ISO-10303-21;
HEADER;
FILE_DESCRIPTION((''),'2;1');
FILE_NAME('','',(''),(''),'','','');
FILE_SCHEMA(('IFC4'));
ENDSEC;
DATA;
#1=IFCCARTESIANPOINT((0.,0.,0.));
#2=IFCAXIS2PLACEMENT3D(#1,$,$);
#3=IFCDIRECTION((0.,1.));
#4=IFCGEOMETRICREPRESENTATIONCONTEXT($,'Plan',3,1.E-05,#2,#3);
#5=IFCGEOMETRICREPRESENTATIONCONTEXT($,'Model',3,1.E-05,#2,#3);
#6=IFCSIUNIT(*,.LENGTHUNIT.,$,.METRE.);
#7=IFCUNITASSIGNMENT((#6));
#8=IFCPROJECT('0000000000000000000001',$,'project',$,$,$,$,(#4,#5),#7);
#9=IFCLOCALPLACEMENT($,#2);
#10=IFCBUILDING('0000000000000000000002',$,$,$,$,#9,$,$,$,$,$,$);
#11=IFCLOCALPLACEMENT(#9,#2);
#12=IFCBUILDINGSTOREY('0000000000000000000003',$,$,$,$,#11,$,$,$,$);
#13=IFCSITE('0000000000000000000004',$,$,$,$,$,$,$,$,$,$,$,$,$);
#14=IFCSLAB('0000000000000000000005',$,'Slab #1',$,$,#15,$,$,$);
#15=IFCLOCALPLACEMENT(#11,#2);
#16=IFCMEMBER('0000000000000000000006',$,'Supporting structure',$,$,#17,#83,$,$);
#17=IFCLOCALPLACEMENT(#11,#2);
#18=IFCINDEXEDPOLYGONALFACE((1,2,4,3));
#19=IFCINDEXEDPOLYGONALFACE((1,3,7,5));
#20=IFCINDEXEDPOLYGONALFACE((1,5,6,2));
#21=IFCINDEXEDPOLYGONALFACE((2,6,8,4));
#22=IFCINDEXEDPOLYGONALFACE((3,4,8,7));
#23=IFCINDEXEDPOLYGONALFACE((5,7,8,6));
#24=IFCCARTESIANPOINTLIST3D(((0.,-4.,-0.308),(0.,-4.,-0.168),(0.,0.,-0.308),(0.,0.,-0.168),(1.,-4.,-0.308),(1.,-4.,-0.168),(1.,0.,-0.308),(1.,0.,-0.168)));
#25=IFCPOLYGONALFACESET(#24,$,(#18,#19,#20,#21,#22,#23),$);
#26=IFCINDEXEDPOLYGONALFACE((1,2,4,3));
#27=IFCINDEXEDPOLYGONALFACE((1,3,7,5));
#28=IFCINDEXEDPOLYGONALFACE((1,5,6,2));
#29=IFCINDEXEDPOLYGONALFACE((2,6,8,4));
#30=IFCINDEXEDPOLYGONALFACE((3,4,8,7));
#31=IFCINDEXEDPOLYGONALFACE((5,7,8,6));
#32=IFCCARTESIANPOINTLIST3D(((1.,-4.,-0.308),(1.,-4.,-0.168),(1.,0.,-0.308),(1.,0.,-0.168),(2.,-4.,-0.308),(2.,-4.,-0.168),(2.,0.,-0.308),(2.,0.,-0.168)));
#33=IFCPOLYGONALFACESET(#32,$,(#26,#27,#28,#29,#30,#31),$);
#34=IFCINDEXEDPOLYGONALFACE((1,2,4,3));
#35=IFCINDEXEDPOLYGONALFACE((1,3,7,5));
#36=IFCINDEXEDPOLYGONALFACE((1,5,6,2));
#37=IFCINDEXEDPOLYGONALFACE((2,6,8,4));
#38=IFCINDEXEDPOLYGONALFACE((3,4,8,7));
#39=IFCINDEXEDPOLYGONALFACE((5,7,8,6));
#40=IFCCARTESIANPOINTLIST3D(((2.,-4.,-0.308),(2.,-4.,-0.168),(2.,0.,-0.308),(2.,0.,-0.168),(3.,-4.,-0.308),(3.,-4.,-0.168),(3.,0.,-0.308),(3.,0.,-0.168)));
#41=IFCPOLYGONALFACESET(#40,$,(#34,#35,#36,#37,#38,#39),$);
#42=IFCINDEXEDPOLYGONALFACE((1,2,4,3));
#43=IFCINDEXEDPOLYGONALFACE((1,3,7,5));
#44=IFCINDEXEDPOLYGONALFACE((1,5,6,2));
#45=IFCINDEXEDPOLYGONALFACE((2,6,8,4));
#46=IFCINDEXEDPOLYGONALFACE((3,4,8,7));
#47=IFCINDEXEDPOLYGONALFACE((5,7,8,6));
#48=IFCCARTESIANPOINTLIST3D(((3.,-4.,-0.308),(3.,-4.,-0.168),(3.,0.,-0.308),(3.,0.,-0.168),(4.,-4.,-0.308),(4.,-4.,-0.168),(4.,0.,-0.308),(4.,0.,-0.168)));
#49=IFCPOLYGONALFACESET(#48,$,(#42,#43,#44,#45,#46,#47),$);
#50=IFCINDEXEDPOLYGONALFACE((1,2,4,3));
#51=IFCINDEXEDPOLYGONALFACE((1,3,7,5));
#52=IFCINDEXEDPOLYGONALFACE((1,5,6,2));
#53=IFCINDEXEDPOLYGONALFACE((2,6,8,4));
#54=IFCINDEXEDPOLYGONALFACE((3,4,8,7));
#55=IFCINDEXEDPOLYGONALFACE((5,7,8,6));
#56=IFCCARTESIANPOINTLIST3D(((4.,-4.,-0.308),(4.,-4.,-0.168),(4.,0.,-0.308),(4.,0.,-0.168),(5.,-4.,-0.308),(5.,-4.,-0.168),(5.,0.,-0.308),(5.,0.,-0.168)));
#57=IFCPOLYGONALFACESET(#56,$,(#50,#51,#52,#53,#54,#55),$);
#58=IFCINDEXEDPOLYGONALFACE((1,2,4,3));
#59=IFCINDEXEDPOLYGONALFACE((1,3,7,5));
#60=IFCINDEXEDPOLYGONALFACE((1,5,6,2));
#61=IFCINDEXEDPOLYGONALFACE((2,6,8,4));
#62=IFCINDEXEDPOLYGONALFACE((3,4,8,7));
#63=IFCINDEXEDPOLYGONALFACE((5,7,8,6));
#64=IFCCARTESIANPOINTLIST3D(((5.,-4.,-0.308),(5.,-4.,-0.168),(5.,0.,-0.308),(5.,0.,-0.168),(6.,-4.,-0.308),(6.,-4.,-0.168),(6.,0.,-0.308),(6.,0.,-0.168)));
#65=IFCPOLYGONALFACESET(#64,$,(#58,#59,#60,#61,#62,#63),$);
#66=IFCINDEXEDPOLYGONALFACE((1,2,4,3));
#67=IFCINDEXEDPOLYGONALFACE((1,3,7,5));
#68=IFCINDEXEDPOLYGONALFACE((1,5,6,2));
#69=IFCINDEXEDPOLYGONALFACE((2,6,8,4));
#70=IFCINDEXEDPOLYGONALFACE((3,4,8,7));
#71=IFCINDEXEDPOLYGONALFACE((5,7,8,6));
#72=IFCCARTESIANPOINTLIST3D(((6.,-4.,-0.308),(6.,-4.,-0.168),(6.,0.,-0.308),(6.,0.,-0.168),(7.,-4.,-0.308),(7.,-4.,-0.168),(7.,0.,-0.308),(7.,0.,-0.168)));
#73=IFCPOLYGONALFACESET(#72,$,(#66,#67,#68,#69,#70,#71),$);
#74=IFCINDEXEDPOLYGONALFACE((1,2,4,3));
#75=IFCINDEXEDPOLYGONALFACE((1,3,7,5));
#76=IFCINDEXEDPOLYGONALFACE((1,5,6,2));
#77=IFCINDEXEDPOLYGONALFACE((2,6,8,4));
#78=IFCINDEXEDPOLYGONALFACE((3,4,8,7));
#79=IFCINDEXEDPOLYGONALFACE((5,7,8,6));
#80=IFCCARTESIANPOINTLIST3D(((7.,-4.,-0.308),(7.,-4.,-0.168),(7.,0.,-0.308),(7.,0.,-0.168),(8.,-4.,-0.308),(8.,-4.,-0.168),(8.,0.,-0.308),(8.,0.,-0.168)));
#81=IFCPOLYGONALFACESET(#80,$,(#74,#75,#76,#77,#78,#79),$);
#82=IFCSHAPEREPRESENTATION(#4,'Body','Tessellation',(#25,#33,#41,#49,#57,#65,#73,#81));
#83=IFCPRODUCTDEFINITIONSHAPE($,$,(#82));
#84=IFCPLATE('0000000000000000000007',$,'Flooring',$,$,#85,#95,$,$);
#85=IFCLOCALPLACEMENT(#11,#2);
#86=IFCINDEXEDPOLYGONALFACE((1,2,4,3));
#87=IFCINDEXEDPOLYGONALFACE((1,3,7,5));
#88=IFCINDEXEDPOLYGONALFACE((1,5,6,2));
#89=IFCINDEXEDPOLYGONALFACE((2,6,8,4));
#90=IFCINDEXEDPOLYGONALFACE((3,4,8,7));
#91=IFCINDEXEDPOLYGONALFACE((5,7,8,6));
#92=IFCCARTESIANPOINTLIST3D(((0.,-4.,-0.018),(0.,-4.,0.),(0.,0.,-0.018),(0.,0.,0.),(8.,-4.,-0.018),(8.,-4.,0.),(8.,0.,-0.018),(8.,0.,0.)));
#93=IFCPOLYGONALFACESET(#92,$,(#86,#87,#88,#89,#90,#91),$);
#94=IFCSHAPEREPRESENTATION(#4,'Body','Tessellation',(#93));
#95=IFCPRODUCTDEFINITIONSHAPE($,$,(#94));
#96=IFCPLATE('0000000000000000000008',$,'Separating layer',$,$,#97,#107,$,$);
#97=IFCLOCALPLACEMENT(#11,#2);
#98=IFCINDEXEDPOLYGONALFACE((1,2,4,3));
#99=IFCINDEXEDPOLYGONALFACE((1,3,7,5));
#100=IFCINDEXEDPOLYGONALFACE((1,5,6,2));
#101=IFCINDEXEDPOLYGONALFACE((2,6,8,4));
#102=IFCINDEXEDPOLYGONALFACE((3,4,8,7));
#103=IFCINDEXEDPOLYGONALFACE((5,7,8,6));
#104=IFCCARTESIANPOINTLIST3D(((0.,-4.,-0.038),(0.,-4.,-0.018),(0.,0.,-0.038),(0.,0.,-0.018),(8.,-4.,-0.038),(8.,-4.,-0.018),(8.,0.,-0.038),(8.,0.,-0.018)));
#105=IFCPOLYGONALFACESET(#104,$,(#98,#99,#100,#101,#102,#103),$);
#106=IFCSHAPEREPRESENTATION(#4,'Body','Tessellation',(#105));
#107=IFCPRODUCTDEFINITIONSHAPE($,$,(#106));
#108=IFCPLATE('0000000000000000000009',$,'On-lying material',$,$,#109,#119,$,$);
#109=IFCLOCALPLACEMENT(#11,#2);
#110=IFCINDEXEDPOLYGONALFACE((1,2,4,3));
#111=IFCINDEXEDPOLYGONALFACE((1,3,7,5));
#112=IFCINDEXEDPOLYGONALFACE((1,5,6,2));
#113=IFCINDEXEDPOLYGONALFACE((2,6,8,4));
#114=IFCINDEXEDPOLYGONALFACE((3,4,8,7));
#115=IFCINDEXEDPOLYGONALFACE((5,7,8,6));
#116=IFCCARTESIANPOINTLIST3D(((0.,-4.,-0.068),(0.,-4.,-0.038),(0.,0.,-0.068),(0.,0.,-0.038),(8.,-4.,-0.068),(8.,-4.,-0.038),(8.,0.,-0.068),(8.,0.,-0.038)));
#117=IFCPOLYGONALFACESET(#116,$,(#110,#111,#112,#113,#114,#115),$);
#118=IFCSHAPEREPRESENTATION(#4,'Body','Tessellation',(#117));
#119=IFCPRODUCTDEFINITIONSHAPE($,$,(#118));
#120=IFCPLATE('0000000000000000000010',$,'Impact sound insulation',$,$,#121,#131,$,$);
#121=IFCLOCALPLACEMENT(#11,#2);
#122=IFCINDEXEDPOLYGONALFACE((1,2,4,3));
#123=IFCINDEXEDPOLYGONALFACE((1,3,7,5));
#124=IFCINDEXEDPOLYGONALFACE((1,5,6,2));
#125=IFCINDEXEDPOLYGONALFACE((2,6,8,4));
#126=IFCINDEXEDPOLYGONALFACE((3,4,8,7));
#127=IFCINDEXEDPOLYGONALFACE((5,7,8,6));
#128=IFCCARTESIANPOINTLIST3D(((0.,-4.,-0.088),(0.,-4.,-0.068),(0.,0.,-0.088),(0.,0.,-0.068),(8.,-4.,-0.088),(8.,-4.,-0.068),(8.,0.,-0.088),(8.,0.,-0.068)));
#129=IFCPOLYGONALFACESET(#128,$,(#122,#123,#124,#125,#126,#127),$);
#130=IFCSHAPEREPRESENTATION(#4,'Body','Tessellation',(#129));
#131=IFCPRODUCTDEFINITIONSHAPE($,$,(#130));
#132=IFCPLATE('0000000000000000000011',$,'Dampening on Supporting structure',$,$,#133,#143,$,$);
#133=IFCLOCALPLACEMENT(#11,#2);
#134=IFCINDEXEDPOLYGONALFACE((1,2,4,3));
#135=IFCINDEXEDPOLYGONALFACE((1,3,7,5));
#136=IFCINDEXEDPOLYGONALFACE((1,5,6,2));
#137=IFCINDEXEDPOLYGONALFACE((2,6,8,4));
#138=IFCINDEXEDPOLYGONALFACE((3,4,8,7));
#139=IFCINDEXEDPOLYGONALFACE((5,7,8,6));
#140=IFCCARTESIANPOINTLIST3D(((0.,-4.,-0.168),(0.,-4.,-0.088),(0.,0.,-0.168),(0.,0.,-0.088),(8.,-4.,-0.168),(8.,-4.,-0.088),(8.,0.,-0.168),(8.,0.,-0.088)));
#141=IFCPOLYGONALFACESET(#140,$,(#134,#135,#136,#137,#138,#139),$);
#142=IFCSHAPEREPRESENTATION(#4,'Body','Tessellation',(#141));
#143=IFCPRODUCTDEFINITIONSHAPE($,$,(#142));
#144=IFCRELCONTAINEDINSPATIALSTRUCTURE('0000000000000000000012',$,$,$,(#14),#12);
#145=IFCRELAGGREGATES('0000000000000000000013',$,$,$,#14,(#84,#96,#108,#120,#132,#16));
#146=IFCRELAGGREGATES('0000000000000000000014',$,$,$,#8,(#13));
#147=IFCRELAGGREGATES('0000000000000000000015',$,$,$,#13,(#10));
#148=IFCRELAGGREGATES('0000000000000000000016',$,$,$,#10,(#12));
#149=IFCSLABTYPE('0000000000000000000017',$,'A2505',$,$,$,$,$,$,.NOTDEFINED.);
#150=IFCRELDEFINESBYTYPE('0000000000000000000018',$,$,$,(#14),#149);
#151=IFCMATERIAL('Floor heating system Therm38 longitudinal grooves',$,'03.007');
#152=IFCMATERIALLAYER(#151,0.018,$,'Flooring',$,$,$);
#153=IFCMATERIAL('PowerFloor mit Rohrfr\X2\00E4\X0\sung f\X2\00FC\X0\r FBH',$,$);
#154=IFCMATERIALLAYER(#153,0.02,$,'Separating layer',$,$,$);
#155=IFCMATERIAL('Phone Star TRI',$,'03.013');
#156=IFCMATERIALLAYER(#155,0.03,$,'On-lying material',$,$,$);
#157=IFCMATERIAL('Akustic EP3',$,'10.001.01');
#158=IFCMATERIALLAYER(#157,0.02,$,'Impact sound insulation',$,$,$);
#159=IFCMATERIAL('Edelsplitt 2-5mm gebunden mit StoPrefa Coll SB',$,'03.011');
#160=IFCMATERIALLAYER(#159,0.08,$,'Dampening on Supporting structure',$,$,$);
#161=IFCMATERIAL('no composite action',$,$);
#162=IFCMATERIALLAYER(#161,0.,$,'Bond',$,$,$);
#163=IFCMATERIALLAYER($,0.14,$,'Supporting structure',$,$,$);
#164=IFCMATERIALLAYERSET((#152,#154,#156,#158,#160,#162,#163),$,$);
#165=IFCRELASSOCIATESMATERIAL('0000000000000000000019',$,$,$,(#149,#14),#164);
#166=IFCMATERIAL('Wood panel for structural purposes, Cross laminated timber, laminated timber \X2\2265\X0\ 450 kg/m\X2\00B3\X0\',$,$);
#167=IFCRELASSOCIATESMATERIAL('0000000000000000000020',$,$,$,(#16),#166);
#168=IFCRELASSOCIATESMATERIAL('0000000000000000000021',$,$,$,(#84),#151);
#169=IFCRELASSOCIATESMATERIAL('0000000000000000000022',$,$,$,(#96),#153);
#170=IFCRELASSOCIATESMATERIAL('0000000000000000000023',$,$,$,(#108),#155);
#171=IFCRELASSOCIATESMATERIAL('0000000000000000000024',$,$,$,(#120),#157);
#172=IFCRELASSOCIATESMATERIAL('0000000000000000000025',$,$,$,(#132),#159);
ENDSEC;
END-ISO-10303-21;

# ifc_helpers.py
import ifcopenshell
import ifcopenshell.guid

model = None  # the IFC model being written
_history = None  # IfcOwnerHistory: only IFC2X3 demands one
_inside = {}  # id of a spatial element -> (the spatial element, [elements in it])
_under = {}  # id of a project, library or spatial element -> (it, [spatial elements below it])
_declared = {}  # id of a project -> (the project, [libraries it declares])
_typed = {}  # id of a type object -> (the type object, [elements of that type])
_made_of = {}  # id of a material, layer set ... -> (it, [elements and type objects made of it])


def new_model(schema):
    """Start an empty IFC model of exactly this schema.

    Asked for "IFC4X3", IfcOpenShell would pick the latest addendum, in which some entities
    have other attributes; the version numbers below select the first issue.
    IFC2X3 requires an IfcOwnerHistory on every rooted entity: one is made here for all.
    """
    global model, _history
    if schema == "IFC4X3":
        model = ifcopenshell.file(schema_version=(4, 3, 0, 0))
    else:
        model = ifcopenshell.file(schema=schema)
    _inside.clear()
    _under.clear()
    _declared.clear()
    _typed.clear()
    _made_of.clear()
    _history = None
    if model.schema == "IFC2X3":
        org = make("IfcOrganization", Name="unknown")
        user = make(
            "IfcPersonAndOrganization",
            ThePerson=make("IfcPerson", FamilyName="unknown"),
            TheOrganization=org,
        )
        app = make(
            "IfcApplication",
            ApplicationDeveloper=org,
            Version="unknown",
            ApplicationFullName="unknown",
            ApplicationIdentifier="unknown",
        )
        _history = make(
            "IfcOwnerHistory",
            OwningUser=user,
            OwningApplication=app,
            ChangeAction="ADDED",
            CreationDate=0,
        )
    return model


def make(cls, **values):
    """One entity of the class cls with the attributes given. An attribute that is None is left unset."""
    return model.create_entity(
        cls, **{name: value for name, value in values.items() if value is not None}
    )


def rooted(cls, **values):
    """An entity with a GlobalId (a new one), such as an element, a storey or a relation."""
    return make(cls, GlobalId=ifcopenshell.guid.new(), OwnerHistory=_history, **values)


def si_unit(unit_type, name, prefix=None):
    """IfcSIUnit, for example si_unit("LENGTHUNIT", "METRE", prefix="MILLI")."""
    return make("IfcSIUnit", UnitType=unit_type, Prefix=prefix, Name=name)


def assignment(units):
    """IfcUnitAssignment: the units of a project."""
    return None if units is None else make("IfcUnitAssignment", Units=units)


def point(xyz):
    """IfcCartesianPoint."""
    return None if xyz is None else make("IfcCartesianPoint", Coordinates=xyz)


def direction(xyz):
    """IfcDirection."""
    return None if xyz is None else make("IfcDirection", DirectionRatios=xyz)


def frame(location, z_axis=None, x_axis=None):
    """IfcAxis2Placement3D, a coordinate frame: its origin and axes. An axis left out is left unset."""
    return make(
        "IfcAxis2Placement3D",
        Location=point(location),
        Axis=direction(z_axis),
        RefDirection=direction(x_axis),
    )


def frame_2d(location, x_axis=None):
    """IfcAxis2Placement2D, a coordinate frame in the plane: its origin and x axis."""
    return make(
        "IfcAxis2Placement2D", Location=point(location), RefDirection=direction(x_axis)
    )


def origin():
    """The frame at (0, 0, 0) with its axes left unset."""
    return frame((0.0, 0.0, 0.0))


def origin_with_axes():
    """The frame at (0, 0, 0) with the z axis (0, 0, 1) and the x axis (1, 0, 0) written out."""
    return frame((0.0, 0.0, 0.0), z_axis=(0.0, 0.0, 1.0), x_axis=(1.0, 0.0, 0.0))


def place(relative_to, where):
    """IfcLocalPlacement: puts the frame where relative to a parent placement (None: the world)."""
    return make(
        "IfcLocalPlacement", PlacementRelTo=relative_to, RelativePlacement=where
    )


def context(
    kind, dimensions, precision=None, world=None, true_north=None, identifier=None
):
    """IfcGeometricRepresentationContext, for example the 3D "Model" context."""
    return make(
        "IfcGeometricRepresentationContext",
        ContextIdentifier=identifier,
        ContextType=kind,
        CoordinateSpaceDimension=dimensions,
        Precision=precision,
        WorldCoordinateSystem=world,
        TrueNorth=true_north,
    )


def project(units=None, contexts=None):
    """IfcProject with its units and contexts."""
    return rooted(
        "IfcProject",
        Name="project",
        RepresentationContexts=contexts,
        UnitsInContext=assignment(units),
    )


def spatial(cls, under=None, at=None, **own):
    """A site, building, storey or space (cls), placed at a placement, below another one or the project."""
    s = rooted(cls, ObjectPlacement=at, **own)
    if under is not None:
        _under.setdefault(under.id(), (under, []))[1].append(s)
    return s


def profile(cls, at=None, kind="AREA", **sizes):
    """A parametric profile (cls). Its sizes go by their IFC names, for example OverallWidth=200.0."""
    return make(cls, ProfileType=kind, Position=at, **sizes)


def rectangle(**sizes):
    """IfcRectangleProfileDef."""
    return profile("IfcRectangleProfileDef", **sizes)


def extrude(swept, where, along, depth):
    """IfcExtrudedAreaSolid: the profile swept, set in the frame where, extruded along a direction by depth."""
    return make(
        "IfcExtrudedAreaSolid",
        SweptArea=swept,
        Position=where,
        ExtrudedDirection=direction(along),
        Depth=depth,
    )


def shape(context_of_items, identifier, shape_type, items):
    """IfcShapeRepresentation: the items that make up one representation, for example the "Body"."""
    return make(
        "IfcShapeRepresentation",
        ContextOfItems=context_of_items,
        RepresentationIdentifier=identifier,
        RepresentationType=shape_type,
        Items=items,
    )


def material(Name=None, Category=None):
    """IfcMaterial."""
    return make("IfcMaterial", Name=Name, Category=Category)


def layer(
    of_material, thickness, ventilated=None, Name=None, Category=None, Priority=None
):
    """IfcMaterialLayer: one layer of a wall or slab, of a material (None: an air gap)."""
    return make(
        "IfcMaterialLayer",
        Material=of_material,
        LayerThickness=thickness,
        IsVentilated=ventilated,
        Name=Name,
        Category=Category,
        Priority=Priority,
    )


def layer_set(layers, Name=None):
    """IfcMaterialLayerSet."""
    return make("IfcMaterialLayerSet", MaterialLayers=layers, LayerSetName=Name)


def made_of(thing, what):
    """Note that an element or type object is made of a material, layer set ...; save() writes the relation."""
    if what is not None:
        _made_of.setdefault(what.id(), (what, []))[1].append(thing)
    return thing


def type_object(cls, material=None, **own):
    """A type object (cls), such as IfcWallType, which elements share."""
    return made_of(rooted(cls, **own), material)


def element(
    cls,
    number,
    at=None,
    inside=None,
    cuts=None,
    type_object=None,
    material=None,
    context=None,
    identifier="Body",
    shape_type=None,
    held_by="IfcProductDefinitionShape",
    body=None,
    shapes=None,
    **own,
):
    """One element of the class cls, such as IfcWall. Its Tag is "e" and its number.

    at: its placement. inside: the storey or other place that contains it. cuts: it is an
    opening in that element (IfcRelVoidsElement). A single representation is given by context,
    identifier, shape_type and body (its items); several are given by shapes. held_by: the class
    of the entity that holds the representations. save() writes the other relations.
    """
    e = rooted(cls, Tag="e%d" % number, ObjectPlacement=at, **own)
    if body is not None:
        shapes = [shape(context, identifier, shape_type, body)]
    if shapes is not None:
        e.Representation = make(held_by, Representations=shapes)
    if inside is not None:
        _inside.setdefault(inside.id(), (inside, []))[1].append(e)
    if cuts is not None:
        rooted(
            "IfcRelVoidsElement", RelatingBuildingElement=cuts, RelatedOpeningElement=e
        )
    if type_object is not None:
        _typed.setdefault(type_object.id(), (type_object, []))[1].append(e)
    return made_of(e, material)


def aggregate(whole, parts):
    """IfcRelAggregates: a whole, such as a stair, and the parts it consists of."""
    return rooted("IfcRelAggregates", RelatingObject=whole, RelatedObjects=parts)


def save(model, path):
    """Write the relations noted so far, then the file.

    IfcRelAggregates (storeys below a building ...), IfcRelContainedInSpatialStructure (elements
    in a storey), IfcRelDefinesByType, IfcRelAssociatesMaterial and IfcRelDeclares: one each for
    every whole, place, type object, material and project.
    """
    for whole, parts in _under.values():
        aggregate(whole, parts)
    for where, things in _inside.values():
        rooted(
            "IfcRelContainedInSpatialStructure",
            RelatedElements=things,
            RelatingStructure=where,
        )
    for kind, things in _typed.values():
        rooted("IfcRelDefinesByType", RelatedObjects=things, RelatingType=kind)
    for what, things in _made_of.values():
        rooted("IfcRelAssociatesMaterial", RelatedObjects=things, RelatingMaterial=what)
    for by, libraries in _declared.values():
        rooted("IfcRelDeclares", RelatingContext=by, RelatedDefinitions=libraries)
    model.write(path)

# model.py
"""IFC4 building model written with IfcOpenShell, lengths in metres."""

from ifc_helpers import new_model, si_unit, direction, frame, frame_2d, origin, origin_with_axes, place, context, project, spatial, rectangle, extrude, material, layer, layer_set, type_object, element, aggregate, save


model = new_model("IFC4")

# Units and contexts
plan_context = context("Plan", 3, precision=1e-05, world=origin(), true_north=direction((0.0, 1.0)))
model_context = context("Model", 3, precision=1e-05, world=origin(), true_north=direction((0.0, 1.0)))
ifc_project = project(units=[si_unit("LENGTHUNIT", "METRE")], contexts=[plan_context, model_context])

# Site, building, storey
site = spatial("IfcSite", under=ifc_project)
building_placement = place(None, origin())
building = spatial("IfcBuilding", under=site, at=building_placement)
storey_placement = place(building_placement, origin())
storey = spatial("IfcBuildingStorey", under=building, at=storey_placement)

# Slab, member, plates
ifc_material_1 = material(Name="Floor heating system Therm38 longitudinal grooves", Category="03.007")
ifc_layer_1 = layer(ifc_material_1, 0.018, Name="Flooring")
ifc_material_2 = material(Name="PowerFloor mit Rohrfräsung für FBH")
ifc_layer_2 = layer(ifc_material_2, 0.02, Name="Separating layer")
ifc_material_3 = material(Name="Phone Star TRI", Category="03.013")
ifc_layer_3 = layer(ifc_material_3, 0.03, Name="On-lying material")
ifc_material_4 = material(Name="Akustic EP3", Category="10.001.01")
ifc_layer_4 = layer(ifc_material_4, 0.02, Name="Impact sound insulation")
ifc_material_5 = material(Name="Edelsplitt 2-5mm gebunden mit StoPrefa Coll SB", Category="03.011")
ifc_layer_5 = layer(ifc_material_5, 0.08, Name="Dampening on Supporting structure")
ifc_material_6 = material(Name="no composite action")
ifc_layer_6 = layer(ifc_material_6, 0.0, Name="Bond")
ifc_layer_7 = layer(None, 0.14, Name="Supporting structure")
ifc_layer_set = layer_set([ifc_layer_1, ifc_layer_2, ifc_layer_3, ifc_layer_4, ifc_layer_5, ifc_layer_6, ifc_layer_7])
slab_type = type_object("IfcSlabType", Name="A2505", PredefinedType="NOTDEFINED", material=ifc_layer_set)
slab_placement = place(None, frame((0.0, 0.0, 0.0), z_axis=(0.0, 0.0, -1.0), x_axis=(1.0, 0.0, 0.0)))
slab = element("IfcSlab", 1, at=slab_placement, inside=storey, type_object=slab_type, material=ifc_layer_set, Name="Slab #1")
ifc_material_7 = material(Name="Wood panel for structural purposes, Cross laminated timber, laminated timber ≥ 450 kg/m³")
member_placement = place(slab_placement, origin())
member = element("IfcMember", 2, at=member_placement, material=ifc_material_7, Name="Supporting structure", context=plan_context, shape_type="SweptSolid", body=[
    extrude(rectangle(XDim=1.0, YDim=0.14, at=frame_2d((0.5, 0.07), x_axis=(1.0, 0.0))), frame((0.0, 4.0, 0.168), z_axis=(0.0, -1.0, 0.0), x_axis=(1.0, 0.0, 0.0)), (0.0, 0.0, 1.0), 4.0),
    extrude(rectangle(XDim=1.0, YDim=0.14, at=frame_2d((0.5, 0.07), x_axis=(1.0, 0.0))), frame((1.0, 4.0, 0.168), z_axis=(0.0, -1.0, 0.0), x_axis=(1.0, 0.0, 0.0)), (0.0, 0.0, 1.0), 4.0),
    extrude(rectangle(XDim=1.0, YDim=0.14, at=frame_2d((0.5, 0.07), x_axis=(1.0, 0.0))), frame((2.0, 4.0, 0.168), z_axis=(0.0, -1.0, 0.0), x_axis=(1.0, 0.0, 0.0)), (0.0, 0.0, 1.0), 4.0),
    extrude(rectangle(XDim=1.0, YDim=0.14, at=frame_2d((0.5, 0.07), x_axis=(1.0, 0.0))), frame((3.0, 4.0, 0.168), z_axis=(0.0, -1.0, 0.0), x_axis=(1.0, 0.0, 0.0)), (0.0, 0.0, 1.0), 4.0),
    extrude(rectangle(XDim=1.0, YDim=0.14, at=frame_2d((0.5, 0.07), x_axis=(1.0, 0.0))), frame((4.0, 4.0, 0.168), z_axis=(0.0, -1.0, 0.0), x_axis=(1.0, 0.0, 0.0)), (0.0, 0.0, 1.0), 4.0),
    extrude(rectangle(XDim=1.0, YDim=0.14, at=frame_2d((0.5, 0.07), x_axis=(1.0, 0.0))), frame((5.0, 4.0, 0.168), z_axis=(0.0, -1.0, 0.0), x_axis=(1.0, 0.0, 0.0)), (0.0, 0.0, 1.0), 4.0),
    extrude(rectangle(XDim=1.0, YDim=0.14, at=frame_2d((0.5, 0.07), x_axis=(1.0, 0.0))), frame((6.0, 4.0, 0.168), z_axis=(0.0, -1.0, 0.0), x_axis=(1.0, 0.0, 0.0)), (0.0, 0.0, 1.0), 4.0),
    extrude(rectangle(XDim=1.0, YDim=0.14, at=frame_2d((0.5, 0.07), x_axis=(1.0, 0.0))), frame((7.0, 4.0, 0.168), z_axis=(0.0, -1.0, 0.0), x_axis=(1.0, 0.0, 0.0)), (0.0, 0.0, 1.0), 4.0),
])
plate_1_placement = place(slab_placement, origin())
plate_1 = element("IfcPlate", 3, at=plate_1_placement, material=ifc_material_1, Name="Flooring", context=plan_context, shape_type="SweptSolid", body=[
    extrude(rectangle(XDim=8.0, YDim=4.0, at=frame_2d((4.0, 2.0), x_axis=(1.0, 0.0))), origin_with_axes(), (0.0, 0.0, 1.0), 0.018),
])
plate_2_placement = place(slab_placement, origin())
plate_2 = element("IfcPlate", 4, at=plate_2_placement, material=ifc_material_2, Name="Separating layer", context=plan_context, shape_type="SweptSolid", body=[
    extrude(rectangle(XDim=8.0, YDim=4.0, at=frame_2d((4.0, 2.0), x_axis=(1.0, 0.0))), frame((0.0, 0.0, 0.018), z_axis=(0.0, 0.0, 1.0), x_axis=(1.0, 0.0, 0.0)), (0.0, 0.0, 1.0), 0.02),
])
plate_3_placement = place(slab_placement, origin())
plate_3 = element("IfcPlate", 5, at=plate_3_placement, material=ifc_material_3, Name="On-lying material", context=plan_context, shape_type="SweptSolid", body=[
    extrude(rectangle(XDim=8.0, YDim=4.0, at=frame_2d((4.0, 2.0), x_axis=(1.0, 0.0))), frame((0.0, 0.0, 0.038), z_axis=(0.0, 0.0, 1.0), x_axis=(1.0, 0.0, 0.0)), (0.0, 0.0, 1.0), 0.03),
])
plate_4_placement = place(slab_placement, origin())
plate_4 = element("IfcPlate", 6, at=plate_4_placement, material=ifc_material_4, Name="Impact sound insulation", context=plan_context, shape_type="SweptSolid", body=[
    extrude(rectangle(XDim=8.0, YDim=4.0, at=frame_2d((4.0, 2.0), x_axis=(1.0, 0.0))), frame((0.0, 0.0, 0.068), z_axis=(0.0, 0.0, 1.0), x_axis=(1.0, 0.0, 0.0)), (0.0, 0.0, 1.0), 0.02),
])
plate_5_placement = place(slab_placement, origin())
plate_5 = element("IfcPlate", 7, at=plate_5_placement, material=ifc_material_5, Name="Dampening on Supporting structure", context=plan_context, shape_type="SweptSolid", body=[
    extrude(rectangle(XDim=8.0, YDim=4.0, at=frame_2d((4.0, 2.0), x_axis=(1.0, 0.0))), frame((0.0, 0.0, 0.088), z_axis=(0.0, 0.0, 1.0), x_axis=(1.0, 0.0, 0.0)), (0.0, 0.0, 1.0), 0.08),
])
aggregate(slab, [plate_1, plate_2, plate_3, plate_4, plate_5, member])

save(model, "model.ifc")
